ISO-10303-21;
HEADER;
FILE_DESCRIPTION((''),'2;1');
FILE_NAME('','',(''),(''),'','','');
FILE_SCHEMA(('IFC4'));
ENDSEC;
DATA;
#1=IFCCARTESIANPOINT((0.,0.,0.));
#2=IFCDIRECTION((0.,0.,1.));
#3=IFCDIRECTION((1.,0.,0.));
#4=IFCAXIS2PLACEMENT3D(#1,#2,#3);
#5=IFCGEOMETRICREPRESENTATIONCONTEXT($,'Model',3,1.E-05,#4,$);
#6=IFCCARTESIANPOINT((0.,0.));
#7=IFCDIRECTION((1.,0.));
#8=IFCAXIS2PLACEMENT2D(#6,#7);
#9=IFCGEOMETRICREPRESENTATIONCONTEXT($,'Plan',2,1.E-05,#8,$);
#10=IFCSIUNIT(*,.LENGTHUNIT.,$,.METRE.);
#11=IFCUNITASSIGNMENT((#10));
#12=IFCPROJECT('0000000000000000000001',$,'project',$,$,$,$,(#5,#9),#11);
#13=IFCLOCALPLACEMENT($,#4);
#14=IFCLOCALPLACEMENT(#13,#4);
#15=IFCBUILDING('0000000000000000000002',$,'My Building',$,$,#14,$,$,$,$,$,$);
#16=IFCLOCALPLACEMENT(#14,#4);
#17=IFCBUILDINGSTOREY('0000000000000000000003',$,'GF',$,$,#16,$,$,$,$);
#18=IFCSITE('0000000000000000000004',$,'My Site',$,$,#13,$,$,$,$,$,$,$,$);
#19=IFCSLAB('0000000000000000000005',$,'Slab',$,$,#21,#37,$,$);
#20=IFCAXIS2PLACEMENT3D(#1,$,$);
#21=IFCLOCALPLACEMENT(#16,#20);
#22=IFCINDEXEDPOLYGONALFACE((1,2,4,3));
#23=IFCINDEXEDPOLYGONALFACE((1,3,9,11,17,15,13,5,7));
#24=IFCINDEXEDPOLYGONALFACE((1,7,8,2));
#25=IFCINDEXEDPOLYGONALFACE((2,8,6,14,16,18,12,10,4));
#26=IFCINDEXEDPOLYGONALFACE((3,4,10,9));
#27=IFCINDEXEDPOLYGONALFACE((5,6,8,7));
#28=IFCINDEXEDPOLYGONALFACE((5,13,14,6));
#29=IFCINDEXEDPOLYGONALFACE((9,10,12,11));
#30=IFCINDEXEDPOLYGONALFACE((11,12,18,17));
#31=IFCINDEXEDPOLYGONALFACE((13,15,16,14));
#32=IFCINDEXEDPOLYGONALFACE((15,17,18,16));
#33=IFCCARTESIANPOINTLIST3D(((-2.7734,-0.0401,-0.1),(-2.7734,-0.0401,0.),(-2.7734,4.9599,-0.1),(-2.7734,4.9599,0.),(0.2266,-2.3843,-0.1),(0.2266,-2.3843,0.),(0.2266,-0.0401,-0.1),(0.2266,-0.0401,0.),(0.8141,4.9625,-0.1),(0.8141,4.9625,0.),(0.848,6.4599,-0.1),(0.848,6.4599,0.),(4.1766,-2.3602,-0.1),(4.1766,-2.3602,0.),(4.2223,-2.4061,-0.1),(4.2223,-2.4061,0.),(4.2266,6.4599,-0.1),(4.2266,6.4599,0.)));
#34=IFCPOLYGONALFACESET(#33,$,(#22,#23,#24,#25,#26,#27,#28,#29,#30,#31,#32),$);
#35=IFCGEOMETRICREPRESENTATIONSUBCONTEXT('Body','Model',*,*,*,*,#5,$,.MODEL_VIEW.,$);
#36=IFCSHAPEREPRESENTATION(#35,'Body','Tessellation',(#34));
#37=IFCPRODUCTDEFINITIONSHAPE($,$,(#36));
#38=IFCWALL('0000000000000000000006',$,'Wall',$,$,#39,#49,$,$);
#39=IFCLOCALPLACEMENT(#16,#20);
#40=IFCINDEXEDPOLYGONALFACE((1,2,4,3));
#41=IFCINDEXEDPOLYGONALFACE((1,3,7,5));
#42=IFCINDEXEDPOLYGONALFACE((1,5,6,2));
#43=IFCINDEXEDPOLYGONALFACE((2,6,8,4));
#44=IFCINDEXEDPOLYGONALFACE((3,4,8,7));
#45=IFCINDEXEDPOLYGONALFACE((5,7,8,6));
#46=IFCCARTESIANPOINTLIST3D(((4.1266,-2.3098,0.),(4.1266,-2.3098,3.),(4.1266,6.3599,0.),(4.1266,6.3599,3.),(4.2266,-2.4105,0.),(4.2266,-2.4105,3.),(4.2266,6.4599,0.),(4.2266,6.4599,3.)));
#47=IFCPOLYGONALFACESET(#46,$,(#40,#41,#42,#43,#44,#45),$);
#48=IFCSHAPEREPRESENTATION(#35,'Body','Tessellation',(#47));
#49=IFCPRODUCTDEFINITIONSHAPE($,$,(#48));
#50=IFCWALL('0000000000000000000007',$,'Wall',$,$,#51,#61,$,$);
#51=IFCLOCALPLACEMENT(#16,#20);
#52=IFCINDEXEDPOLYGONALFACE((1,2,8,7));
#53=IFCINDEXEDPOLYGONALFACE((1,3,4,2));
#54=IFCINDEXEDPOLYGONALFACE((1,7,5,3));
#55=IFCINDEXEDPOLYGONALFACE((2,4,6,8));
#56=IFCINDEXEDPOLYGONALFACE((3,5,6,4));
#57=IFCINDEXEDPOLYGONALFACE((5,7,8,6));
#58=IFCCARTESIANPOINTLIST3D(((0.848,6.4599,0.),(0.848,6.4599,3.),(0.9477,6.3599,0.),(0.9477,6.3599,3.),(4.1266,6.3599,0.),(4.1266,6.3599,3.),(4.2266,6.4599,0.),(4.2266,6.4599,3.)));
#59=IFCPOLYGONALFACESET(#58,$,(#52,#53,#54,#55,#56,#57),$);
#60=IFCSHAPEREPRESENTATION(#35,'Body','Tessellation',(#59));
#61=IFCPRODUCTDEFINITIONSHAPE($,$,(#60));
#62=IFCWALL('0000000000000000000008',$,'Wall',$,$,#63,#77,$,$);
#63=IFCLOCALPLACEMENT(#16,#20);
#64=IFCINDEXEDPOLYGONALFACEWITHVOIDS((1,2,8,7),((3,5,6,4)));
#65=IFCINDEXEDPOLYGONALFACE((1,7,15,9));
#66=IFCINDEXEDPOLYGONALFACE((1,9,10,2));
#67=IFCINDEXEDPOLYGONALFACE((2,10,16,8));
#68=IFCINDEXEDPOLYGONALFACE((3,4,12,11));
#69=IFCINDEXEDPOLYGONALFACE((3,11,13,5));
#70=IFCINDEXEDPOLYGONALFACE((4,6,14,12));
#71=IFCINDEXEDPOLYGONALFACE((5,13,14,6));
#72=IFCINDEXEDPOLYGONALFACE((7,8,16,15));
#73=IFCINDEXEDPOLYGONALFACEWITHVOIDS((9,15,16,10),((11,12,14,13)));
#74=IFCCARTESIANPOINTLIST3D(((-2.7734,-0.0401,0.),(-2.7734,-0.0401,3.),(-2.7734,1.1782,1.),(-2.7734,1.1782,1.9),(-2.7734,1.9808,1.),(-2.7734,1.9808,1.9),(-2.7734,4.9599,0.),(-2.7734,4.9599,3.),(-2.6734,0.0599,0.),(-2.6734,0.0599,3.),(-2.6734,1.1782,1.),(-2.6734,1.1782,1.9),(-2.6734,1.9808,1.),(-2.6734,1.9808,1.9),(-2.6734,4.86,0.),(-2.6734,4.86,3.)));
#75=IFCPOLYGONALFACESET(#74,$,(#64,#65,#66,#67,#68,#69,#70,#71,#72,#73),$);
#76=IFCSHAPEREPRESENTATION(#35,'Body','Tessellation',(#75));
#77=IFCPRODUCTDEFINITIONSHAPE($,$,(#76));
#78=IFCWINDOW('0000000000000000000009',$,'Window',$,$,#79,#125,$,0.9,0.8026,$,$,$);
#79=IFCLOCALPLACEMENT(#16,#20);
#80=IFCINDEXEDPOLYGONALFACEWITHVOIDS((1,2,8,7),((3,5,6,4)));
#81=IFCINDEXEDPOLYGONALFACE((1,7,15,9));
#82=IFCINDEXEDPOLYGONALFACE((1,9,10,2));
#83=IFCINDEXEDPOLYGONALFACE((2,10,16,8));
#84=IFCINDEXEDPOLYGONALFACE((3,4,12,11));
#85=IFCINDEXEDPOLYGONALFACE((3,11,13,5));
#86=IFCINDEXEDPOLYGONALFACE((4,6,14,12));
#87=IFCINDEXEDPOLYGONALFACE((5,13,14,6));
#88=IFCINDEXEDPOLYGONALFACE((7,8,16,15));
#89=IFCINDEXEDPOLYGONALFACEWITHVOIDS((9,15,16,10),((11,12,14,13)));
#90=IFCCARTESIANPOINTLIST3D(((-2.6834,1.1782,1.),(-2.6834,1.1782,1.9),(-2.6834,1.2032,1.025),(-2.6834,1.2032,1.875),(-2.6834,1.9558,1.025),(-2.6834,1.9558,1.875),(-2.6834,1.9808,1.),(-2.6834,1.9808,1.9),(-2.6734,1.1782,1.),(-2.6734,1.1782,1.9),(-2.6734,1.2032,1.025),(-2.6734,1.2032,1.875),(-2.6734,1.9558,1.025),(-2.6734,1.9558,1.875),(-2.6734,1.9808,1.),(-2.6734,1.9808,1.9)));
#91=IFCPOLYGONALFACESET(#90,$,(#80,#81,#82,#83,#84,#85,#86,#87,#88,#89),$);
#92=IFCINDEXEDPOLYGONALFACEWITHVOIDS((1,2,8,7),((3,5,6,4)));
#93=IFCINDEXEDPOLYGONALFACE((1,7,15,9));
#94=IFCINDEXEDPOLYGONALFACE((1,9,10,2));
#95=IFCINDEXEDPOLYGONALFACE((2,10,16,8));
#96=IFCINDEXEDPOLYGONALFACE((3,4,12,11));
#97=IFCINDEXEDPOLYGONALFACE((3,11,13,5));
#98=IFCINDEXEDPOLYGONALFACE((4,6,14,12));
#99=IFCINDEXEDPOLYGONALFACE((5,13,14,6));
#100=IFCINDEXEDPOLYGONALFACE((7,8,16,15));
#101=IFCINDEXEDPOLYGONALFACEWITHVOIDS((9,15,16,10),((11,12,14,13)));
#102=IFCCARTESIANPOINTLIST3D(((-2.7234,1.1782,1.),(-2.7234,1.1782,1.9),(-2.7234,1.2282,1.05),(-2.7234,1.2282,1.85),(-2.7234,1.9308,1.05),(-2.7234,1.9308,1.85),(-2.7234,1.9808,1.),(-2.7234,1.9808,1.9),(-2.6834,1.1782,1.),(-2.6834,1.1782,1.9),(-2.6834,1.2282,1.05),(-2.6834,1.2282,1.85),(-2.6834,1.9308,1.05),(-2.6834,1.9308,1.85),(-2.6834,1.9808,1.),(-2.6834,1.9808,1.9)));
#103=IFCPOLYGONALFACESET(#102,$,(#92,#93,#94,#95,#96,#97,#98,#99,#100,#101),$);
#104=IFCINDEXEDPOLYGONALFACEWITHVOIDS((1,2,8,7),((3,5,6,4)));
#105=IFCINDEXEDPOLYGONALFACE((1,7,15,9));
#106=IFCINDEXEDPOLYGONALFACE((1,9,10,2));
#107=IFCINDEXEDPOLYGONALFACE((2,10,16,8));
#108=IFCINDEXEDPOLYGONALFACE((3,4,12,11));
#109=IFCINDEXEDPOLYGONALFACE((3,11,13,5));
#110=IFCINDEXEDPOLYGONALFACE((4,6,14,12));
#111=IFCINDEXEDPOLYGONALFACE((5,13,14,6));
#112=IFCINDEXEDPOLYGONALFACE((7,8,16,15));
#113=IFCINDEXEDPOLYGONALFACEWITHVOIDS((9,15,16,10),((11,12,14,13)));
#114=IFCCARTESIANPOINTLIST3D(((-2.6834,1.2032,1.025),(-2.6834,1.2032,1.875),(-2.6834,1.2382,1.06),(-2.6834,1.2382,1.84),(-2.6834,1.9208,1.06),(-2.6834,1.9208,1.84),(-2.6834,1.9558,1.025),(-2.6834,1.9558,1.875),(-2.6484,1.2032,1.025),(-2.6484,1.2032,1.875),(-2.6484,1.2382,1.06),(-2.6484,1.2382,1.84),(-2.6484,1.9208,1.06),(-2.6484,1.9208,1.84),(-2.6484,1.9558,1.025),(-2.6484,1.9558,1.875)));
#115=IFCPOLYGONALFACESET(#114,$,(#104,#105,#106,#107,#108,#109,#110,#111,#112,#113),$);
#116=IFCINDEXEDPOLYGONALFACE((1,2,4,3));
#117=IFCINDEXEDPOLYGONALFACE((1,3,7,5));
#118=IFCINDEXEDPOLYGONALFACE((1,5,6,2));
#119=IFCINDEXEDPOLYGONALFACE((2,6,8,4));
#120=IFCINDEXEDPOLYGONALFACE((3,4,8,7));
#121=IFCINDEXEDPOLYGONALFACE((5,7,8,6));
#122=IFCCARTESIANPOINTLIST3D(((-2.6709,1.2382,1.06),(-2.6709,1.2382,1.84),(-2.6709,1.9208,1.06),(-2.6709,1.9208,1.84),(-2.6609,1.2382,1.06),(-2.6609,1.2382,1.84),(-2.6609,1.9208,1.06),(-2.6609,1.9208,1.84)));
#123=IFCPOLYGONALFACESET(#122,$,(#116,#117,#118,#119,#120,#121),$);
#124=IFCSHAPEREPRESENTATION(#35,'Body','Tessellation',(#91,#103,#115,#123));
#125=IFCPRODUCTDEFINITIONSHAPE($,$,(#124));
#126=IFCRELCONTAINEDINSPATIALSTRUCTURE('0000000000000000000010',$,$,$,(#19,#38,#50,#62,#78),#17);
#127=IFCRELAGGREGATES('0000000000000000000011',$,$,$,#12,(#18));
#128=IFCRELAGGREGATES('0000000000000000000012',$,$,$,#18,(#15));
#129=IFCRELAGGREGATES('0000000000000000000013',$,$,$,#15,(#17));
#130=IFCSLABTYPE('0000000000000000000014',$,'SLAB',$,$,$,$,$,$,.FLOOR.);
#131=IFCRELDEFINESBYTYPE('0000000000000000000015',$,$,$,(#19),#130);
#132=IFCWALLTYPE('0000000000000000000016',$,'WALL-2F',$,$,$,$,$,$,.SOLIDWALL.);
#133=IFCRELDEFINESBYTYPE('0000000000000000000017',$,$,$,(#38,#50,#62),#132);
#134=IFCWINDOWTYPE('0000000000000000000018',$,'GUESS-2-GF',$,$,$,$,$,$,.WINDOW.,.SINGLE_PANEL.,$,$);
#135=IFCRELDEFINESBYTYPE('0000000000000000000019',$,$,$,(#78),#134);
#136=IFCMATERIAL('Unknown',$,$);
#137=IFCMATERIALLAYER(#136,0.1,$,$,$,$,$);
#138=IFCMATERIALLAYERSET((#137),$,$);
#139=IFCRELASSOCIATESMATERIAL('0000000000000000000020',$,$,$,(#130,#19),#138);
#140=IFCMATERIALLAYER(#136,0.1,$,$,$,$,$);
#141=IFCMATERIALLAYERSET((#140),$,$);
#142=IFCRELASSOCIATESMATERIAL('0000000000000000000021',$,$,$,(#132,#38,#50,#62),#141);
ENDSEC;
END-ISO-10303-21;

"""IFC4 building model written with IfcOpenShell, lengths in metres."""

from ifc_helpers import new_model, entity, si_unit, frame, origin_with_axes, origin_2d_with_axis, place, context, subcontext, project, spatial, line, indexed_curve, outline, extrude, shape, source, transform, mapped, material, layer, layer_set, layer_usage, type_object, type_shapes, element, fill, save


model = new_model("IFC4")

# Units and contexts
model_context = context("Model", 3, precision=1e-05, world=origin_with_axes())
plan_context = context("Plan", 2, precision=1e-05, world=origin_2d_with_axis())
body_context_1 = subcontext(model_context, "Body", "Model", "MODEL_VIEW")
body_context_2 = subcontext(plan_context, "Body", "Plan", "PLAN_VIEW")
ifc_project = project(units=[si_unit("LENGTHUNIT", "METRE")], contexts=[model_context, plan_context])

# Site, building, storey
site_placement = place(None, origin_with_axes())
site = spatial("IfcSite", under=ifc_project, at=site_placement, Name="My Site")
building_placement = place(site_placement, origin_with_axes())
building = spatial("IfcBuilding", under=site, at=building_placement, Name="My Building")
storey_placement = place(building_placement, origin_with_axes())
storey = spatial("IfcBuildingStorey", under=building, at=storey_placement, Name="GF")

# Slab
ifc_material = material(Name="Unknown")
ifc_layer_1 = layer(ifc_material, 0.1)
ifc_layer_set_1 = layer_set([ifc_layer_1])
ifc_layer_usage_1 = layer_usage(ifc_layer_set_1, "AXIS3", "POSITIVE", -0.1)
slab_type = type_object("IfcSlabType", Name="SLAB", PredefinedType="FLOOR", material=ifc_layer_set_1)
slab_placement = place(storey_placement, frame((4.2223, -2.4061, 0.0), z_axis=(0.0, 0.0, 1.0), x_axis=(1.0, 0.0, 0.0)))
element("IfcSlab", 1, at=slab_placement, inside=storey, type_object=slab_type, material=ifc_layer_usage_1, Name="Slab", context=body_context_1, shape_type="SweptSolid", body=[
    extrude(outline(indexed_curve([(0.0, 0.0), (0.0043, 8.866), (-3.3742, 8.866), (-3.4082, 7.3687), (-6.9957, 7.366), (-6.9957, 2.366), (-3.9957, 2.366), (-3.9957, 0.0219), (-0.0457, 0.046), (0.0, 0.0)])), frame((0.0, 0.0, -0.1), z_axis=(0.0, 0.0, 1.0), x_axis=(1.0, 0.0, 0.0)), (0.0, 0.0, 1.0), 0.1),
])

# Walls
ifc_layer_2 = layer(ifc_material, 0.1)
ifc_layer_set_2 = layer_set([ifc_layer_2])
ifc_layer_usage_2 = layer_usage(ifc_layer_set_2, "AXIS2", "POSITIVE", 0.0)
wall_type_1 = type_object("IfcWallType", Name="WALL-2F", PredefinedType="SOLIDWALL", material=ifc_layer_set_2)
wall_1_placement = place(storey_placement, frame((4.2266, -2.4105, 0.0), z_axis=(0.0, 0.0, 1.0), x_axis=(0.0, 1.0, 0.0)))
element("IfcWall", 2, at=wall_1_placement, inside=storey, type_object=wall_type_1, material=ifc_layer_usage_2, Name="Wall", context=body_context_1, shape_type="SweptSolid", body=[
    extrude(outline(indexed_curve([(0.0, 0.0), (0.1007, 0.1), (8.7704, 0.1), (8.8704, 0.0)], segments=[line(1, 2, 3, 4, 1)])), origin_with_axes(), (0.0, 0.0, 1.0), 3.0),
])
ifc_layer_usage_3 = layer_usage(ifc_layer_set_2, "AXIS2", "POSITIVE", 0.0)
wall_2_placement = place(storey_placement, frame((4.2266, 6.4599, 0.0), z_axis=(0.0, 0.0, 1.0), x_axis=(-1.0, 0.0, 0.0)))
element("IfcWall", 3, at=wall_2_placement, inside=storey, type_object=wall_type_1, material=ifc_layer_usage_3, Name="Wall", context=body_context_1, shape_type="SweptSolid", body=[
    extrude(outline(indexed_curve([(0.0, 0.0), (0.1, 0.1), (3.2789, 0.1), (3.3786, 0.0)], segments=[line(1, 2, 3, 4, 1)])), origin_with_axes(), (0.0, 0.0, 1.0), 3.0),
])

# Wall, opening, window
ifc_layer_usage_4 = layer_usage(ifc_layer_set_2, "AXIS2", "POSITIVE", 0.0)
wall_3_placement = place(storey_placement, frame((-2.7734, 4.8599, 0.0), z_axis=(0.0, 0.0, 1.0), x_axis=(0.0, -1.0, 0.0)))
wall_3 = element("IfcWall", 4, at=wall_3_placement, inside=storey, type_object=wall_type_1, material=ifc_layer_usage_4, Name="Wall", context=body_context_1, shape_type="SweptSolid", body=[
    extrude(outline(indexed_curve([(-0.1, 0.0), (-0.0001, 0.1), (4.8, 0.1), (4.9, 0.0)], segments=[line(1, 2, 3, 4, 1)])), origin_with_axes(), (0.0, 0.0, 1.0), 3.0),
])
shared_shape_1 = source(origin_with_axes(), body_context_1, "Body", "SweptSolid", [
    extrude(outline(indexed_curve([(0.0, 0.0), (0.8026, 0.0), (0.8026, 0.9), (0.0, 0.9)], segments=[line(1, 2, 3, 4, 1)])), frame((0.0, -0.6, 0.0), z_axis=(0.0, -1.0, 0.0), x_axis=(1.0, 0.0, 0.0)), (0.0, 0.0, -1.0), 1.2),
])
opening_1_placement = place(wall_3_placement, frame((2.8791, 0.0, 1.0), z_axis=(0.0, 0.0, 1.0), x_axis=(1.0, 0.0, 0.0)))
opening_1 = element("IfcOpeningElement", 5, at=opening_1_placement, cuts=wall_3, PredefinedType="OPENING", context=body_context_1, shape_type="MappedRepresentation", body=[
    mapped(shared_shape_1, transform((0.0, 0.0, 0.0), x_axis=(1.0, 0.0, 0.0), y_axis=(0.0, 1.0, 0.0), z_axis=(0.0, 0.0, 1.0), scale=1.0)),
])
window_type_1 = type_object("IfcWindowType", Name="GUESS-2-GF", PartitioningType="SINGLE_PANEL", PredefinedType="WINDOW")
shared_shape_2 = source(origin_with_axes(), body_context_1, "Body", "SweptSolid", [
    extrude(outline(indexed_curve([(0.0, 0.0), (0.8026, 0.0), (0.8026, 0.9), (0.0, 0.9)], segments=[line(1, 2, 3, 4, 1)]), holes=[indexed_curve([(0.025, 0.025), (0.7776, 0.025), (0.7776, 0.875), (0.025, 0.875)], segments=[line(1, 2, 3, 4, 1)])]), frame((0.0, 0.09, 0.0), z_axis=(0.0, -1.0, 0.0), x_axis=(1.0, 0.0, 0.0)), (0.0, 0.0, -1.0), 0.01),
    extrude(outline(indexed_curve([(0.0, 0.0), (0.8026, 0.0), (0.8026, 0.9), (0.0, 0.9)], segments=[line(1, 2, 3, 4, 1)]), holes=[indexed_curve([(0.05, 0.05), (0.7526, 0.05), (0.7526, 0.85), (0.05, 0.85)], segments=[line(1, 2, 3, 4, 1)])]), frame((0.0, 0.05, 0.0), z_axis=(0.0, -1.0, 0.0), x_axis=(1.0, 0.0, 0.0)), (0.0, 0.0, -1.0), 0.04),
    extrude(outline(indexed_curve([(0.0, 0.0), (0.7526, 0.0), (0.7526, 0.85), (0.0, 0.85)], segments=[line(1, 2, 3, 4, 1)]), holes=[indexed_curve([(0.035, 0.035), (0.7176, 0.035), (0.7176, 0.815), (0.035, 0.815)], segments=[line(1, 2, 3, 4, 1)])]), frame((0.025, 0.09, 0.025), z_axis=(0.0, -1.0, 0.0), x_axis=(1.0, 0.0, 0.0)), (0.0, 0.0, -1.0), 0.035),
    extrude(outline(indexed_curve([(0.035, 0.035), (0.7176, 0.035), (0.7176, 0.815), (0.035, 0.815)], segments=[line(1, 2, 3, 4, 1)])), frame((0.025, 0.1025, 0.025), z_axis=(0.0, -1.0, 0.0), x_axis=(1.0, 0.0, 0.0)), (0.0, 0.0, -1.0), 0.01),
])
shared_shape_3 = source(origin_with_axes(), body_context_2, "Body", "Curve2D", [
    entity("IfcIndexedPolyCurve", entity("IfcCartesianPointList2D", [[0.05, 0.05], [0.7526, 0.05]])),
    entity("IfcIndexedPolyCurve", entity("IfcCartesianPointList2D", [[0.0, 0.1], [0.025, 0.1], [0.025, 0.09], [0.05, 0.09], [0.05, 0.05], [0.0, 0.05]]), [entity("IfcLineIndex", [1, 2, 3, 4, 5, 6, 1])]),
    entity("IfcIndexedPolyCurve", entity("IfcCartesianPointList2D", [[0.8026, 0.1], [0.7776, 0.1], [0.7776, 0.09], [0.7526, 0.09], [0.7526, 0.05], [0.8026, 0.05]]), [entity("IfcLineIndex", [1, 2, 3, 4, 5, 6, 1])]),
    entity("IfcIndexedPolyCurve", entity("IfcCartesianPointList2D", [[0.025, 0.09], [0.06, 0.09], [0.06, 0.125], [0.025, 0.125]]), [entity("IfcLineIndex", [1, 2, 3, 4, 1])]),
    entity("IfcIndexedPolyCurve", entity("IfcCartesianPointList2D", [[0.7776, 0.09], [0.7426, 0.09], [0.7426, 0.125], [0.7776, 0.125]]), [entity("IfcLineIndex", [1, 2, 3, 4, 1])]),
    entity("IfcIndexedPolyCurve", entity("IfcCartesianPointList2D", [[0.06, 0.09], [0.7426, 0.09]])),
    entity("IfcIndexedPolyCurve", entity("IfcCartesianPointList2D", [[0.06, 0.125], [0.7426, 0.125]])),
    entity("IfcIndexedPolyCurve", entity("IfcCartesianPointList2D", [[0.06, 0.1075], [0.7426, 0.1075]])),
])
type_shapes(window_type_1, [shared_shape_2, shared_shape_3])
window_1_placement = place(opening_1_placement, frame((0.0, 0.0, 0.0), z_axis=(0.0, 0.0, 1.0), x_axis=(1.0, 0.0, 0.0)))
window_1 = element("IfcWindow", 6, at=window_1_placement, inside=storey, type_object=window_type_1, Name="Window", OverallHeight=0.9, OverallWidth=0.8026, shapes=[
    shape(body_context_1, "Body", "MappedRepresentation", [mapped(shared_shape_2, transform((0.0, 0.0, 0.0), x_axis=(1.0, 0.0, 0.0), y_axis=(0.0, 1.0, 0.0), z_axis=(0.0, 0.0, 1.0), scale=1.0))]),
    shape(body_context_2, "Body", "MappedRepresentation", [mapped(shared_shape_3, transform((0.0, 0.0, 0.0), x_axis=(1.0, 0.0, 0.0), y_axis=(0.0, 1.0, 0.0), z_axis=(0.0, 0.0, 1.0), scale=1.0))]),
])
fill(opening_1, window_1)

save(model, "model.ifc")
